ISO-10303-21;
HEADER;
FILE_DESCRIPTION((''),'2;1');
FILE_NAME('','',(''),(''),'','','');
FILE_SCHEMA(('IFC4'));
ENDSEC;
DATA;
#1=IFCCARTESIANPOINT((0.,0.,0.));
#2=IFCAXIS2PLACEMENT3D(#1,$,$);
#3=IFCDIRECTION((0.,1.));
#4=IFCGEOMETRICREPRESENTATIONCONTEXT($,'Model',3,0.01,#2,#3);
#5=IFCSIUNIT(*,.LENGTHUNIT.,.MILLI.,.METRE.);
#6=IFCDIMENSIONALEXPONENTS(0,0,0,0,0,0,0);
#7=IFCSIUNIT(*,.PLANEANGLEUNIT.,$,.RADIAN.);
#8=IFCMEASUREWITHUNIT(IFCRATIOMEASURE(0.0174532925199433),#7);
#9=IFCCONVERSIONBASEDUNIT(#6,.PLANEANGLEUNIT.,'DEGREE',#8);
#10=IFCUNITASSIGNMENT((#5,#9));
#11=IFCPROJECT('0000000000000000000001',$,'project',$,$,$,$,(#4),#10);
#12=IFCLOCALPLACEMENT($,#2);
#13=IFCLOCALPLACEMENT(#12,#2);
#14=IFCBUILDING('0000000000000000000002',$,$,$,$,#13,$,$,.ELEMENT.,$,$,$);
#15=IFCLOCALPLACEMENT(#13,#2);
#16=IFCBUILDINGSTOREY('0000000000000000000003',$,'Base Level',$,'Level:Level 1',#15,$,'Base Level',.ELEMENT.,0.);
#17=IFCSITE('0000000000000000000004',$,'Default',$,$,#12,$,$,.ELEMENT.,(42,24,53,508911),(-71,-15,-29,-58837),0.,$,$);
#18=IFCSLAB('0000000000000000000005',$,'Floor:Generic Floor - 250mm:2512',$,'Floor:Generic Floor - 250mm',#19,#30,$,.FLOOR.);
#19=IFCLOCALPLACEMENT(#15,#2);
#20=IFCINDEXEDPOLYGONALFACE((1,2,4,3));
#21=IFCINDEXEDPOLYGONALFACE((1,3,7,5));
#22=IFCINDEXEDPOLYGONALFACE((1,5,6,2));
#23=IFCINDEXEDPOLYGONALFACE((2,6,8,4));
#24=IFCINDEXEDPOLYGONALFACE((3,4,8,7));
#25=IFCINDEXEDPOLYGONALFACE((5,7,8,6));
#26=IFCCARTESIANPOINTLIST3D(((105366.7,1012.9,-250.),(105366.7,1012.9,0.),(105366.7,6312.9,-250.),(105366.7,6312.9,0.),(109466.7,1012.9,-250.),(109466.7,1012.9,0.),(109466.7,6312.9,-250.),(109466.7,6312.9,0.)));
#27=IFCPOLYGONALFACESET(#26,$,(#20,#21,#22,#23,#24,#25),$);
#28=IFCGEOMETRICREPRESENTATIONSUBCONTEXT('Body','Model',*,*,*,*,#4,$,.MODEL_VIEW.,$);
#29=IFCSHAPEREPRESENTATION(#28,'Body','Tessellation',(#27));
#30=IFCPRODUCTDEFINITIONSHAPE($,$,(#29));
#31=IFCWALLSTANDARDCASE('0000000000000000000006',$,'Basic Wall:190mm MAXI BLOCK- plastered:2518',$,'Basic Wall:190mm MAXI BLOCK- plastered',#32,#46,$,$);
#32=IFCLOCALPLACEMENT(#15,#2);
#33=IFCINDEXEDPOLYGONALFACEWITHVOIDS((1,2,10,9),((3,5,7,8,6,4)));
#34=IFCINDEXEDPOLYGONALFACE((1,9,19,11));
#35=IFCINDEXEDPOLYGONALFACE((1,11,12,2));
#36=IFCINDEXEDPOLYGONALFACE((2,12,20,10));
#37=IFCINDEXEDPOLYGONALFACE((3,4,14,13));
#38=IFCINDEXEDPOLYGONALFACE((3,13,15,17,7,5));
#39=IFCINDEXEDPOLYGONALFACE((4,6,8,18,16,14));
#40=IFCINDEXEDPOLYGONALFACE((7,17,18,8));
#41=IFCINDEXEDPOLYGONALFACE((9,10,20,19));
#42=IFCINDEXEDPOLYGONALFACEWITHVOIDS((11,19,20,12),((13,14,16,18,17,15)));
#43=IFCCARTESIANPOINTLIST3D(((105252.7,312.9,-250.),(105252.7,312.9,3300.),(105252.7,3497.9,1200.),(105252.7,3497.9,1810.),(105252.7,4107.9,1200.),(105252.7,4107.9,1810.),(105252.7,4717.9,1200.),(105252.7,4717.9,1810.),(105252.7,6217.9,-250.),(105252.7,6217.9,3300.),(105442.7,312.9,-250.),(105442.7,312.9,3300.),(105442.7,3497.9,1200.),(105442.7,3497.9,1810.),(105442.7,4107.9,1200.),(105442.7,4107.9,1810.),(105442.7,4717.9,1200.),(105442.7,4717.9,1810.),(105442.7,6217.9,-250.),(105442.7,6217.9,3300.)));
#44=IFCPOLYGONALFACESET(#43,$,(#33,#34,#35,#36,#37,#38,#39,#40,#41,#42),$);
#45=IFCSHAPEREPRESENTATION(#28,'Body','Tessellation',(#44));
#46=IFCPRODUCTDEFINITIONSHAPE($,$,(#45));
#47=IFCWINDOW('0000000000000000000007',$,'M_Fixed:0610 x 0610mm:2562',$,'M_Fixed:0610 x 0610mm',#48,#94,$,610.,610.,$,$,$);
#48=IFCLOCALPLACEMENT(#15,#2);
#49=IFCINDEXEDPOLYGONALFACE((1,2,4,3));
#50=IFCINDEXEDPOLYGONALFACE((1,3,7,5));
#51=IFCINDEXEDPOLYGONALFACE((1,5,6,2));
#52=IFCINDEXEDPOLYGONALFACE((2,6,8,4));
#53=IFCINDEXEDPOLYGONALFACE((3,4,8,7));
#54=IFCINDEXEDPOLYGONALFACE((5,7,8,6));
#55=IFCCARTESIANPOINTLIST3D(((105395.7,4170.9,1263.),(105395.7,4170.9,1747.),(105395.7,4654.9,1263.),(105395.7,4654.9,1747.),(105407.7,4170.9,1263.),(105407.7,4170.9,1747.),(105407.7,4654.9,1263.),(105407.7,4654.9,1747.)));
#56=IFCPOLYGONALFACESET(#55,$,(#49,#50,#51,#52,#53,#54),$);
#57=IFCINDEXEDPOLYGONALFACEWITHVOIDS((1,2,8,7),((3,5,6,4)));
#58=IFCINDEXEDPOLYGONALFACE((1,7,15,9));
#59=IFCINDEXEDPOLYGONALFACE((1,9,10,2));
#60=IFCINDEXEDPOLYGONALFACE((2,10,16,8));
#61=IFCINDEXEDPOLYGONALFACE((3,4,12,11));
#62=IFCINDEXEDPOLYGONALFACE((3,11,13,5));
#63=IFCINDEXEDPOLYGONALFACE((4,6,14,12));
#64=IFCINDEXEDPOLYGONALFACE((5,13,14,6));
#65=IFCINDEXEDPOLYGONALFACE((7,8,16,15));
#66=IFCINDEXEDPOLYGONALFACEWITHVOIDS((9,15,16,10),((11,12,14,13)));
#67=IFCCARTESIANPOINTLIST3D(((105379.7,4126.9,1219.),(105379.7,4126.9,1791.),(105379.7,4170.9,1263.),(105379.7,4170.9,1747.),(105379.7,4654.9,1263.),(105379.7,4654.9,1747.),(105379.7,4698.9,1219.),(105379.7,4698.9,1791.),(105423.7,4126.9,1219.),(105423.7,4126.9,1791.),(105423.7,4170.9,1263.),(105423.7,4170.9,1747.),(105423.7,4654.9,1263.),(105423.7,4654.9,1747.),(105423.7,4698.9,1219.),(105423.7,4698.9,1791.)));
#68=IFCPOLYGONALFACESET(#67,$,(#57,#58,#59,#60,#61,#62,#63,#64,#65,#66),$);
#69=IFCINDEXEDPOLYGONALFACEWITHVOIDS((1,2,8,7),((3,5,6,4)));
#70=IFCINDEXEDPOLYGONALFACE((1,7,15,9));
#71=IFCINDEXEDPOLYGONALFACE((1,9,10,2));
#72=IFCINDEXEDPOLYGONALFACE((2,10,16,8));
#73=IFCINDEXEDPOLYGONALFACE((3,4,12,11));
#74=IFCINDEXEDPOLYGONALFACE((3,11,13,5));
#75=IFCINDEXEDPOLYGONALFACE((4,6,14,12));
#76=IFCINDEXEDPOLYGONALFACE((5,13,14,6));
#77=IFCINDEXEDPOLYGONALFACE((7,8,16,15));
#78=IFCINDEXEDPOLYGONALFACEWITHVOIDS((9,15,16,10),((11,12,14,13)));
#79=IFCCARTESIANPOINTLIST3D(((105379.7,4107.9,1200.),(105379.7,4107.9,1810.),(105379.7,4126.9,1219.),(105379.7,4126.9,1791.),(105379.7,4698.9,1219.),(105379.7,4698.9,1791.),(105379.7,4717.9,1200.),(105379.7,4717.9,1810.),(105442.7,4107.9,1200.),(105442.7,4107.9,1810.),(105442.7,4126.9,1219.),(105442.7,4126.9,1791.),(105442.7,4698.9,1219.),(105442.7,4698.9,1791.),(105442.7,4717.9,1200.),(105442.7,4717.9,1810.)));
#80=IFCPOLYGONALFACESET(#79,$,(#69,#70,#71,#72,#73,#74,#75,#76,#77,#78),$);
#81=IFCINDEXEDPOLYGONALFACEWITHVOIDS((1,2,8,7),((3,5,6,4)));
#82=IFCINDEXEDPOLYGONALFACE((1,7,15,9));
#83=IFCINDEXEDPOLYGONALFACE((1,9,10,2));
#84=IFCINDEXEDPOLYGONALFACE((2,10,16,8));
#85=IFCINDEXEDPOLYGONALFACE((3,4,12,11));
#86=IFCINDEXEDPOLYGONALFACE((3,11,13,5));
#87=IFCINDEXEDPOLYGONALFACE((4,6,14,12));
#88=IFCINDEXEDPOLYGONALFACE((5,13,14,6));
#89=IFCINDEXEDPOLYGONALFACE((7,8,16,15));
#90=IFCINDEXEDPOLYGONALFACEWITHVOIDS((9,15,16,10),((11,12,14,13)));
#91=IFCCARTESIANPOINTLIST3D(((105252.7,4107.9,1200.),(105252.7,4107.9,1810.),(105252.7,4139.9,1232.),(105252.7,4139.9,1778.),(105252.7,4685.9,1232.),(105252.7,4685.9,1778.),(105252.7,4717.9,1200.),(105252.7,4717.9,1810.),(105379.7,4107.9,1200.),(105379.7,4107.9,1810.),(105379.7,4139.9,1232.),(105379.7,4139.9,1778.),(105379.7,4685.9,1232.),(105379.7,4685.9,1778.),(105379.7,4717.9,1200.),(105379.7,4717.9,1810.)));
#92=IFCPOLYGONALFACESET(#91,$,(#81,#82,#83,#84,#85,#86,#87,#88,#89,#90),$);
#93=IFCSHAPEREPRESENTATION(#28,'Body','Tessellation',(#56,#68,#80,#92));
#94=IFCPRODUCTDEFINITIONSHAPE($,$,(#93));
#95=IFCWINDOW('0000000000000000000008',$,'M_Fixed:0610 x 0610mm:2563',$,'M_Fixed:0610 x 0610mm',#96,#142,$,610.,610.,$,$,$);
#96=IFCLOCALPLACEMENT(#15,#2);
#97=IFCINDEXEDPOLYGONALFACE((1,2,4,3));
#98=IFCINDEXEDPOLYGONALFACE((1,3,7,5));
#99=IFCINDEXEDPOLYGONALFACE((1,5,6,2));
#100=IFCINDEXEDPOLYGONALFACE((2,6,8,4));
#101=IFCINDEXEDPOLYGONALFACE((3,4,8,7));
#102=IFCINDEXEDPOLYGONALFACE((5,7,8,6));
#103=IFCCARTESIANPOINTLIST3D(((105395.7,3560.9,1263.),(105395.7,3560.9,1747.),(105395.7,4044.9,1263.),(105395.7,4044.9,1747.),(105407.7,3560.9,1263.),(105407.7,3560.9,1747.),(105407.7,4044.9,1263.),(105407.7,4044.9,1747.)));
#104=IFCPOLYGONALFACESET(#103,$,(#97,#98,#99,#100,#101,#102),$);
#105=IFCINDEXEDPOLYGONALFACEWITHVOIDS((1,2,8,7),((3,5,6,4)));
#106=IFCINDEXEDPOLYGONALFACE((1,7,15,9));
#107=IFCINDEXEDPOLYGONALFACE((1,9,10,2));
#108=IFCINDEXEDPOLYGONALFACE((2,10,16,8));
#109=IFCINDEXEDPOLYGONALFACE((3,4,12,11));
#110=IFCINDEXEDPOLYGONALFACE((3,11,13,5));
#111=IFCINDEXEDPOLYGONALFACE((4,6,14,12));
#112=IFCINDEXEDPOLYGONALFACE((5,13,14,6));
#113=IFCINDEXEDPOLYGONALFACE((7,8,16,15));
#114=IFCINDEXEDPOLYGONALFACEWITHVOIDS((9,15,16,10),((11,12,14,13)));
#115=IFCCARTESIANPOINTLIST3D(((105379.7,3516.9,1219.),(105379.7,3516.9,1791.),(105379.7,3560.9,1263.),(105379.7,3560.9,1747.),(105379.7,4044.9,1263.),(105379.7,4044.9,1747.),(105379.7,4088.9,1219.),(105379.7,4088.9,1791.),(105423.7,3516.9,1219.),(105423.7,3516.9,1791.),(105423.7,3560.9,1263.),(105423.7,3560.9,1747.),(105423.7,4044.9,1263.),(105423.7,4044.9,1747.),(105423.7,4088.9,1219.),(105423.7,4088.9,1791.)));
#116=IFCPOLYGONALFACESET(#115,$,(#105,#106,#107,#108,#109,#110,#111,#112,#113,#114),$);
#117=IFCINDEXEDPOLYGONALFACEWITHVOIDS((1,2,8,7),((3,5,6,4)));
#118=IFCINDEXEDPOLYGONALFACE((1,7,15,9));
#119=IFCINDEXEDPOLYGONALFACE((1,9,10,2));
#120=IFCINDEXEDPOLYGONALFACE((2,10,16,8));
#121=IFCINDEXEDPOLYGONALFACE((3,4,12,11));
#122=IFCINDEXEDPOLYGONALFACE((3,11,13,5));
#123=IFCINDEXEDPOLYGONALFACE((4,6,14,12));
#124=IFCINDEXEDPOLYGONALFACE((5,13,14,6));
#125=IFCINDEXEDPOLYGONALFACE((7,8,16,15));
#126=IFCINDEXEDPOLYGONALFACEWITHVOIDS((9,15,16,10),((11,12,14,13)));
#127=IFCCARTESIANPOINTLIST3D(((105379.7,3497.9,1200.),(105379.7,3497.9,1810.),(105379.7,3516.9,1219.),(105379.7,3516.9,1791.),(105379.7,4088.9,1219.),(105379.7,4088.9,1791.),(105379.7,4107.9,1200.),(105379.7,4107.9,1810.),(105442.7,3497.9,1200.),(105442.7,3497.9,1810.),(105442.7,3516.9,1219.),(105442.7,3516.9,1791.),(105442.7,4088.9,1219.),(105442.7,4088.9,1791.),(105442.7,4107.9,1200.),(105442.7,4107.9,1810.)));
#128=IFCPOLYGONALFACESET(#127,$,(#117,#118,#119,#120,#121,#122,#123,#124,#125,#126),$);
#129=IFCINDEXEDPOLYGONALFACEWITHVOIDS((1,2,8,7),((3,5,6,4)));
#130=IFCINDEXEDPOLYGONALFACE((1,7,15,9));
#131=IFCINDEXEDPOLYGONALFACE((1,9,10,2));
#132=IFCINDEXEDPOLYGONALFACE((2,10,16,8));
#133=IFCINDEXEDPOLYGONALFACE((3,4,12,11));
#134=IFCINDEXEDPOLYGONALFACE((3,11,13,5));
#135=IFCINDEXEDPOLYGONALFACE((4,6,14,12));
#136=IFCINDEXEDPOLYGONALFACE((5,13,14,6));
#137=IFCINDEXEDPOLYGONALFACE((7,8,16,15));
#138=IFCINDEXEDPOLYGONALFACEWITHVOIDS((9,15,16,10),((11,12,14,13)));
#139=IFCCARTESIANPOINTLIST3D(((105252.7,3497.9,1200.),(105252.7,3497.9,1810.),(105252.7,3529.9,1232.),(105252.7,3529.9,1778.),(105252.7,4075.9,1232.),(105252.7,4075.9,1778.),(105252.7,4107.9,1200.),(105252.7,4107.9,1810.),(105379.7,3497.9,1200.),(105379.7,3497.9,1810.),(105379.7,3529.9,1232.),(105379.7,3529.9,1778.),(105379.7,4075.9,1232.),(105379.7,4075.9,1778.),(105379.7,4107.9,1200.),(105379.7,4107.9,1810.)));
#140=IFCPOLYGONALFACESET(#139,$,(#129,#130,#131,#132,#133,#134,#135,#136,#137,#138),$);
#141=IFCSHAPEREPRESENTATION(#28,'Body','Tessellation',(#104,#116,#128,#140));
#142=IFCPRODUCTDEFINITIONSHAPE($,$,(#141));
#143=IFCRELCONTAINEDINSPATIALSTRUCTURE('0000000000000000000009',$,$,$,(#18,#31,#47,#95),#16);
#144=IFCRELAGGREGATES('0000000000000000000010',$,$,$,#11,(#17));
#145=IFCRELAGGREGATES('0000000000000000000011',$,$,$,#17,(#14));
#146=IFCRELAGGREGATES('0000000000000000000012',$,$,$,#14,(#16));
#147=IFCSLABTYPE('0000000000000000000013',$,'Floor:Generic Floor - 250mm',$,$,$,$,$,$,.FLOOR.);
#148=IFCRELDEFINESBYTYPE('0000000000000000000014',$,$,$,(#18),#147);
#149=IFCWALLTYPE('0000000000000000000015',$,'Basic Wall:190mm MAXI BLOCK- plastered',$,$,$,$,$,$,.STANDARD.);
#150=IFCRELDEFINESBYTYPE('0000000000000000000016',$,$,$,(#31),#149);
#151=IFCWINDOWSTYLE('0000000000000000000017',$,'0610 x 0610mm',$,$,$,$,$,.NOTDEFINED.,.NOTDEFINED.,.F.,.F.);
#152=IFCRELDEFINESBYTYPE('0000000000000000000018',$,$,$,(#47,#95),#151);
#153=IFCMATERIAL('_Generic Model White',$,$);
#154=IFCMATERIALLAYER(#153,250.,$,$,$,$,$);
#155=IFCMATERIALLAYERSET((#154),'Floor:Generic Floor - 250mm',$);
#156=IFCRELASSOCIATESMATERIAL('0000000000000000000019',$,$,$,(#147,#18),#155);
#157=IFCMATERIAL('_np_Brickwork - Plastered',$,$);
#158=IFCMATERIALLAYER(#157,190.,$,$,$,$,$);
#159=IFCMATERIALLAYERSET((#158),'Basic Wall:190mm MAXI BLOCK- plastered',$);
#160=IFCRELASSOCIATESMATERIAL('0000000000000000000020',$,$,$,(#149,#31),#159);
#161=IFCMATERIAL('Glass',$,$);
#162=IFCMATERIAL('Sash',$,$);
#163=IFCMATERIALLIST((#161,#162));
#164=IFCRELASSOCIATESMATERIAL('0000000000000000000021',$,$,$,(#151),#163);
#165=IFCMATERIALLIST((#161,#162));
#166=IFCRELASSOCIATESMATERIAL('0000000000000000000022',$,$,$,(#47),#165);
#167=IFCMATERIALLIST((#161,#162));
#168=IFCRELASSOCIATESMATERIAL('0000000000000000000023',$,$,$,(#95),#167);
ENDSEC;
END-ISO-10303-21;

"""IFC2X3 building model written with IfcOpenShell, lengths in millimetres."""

from ifc_helpers import new_model, entity, si_unit, converted_unit, direction, frame, frame_2d, origin, origin_2d_with_axis, place, context, subcontext, project, spatial, polyline, rectangle, outline, extrude, source, transform, mapped, material, material_list, layer, layer_set, layer_usage, type_object, type_shapes, element, fill, save


model = new_model("IFC2X3")

# Units and contexts
model_context = context("Model", 3, precision=0.01, world=origin(), true_north=direction((0.0, 1.0)))
body_context = subcontext(model_context, "Body", "Model", "MODEL_VIEW")
ifc_project = project(units=[si_unit("LENGTHUNIT", "METRE", prefix="MILLI"), converted_unit("PLANEANGLEUNIT", "DEGREE", entity("IfcRatioMeasure", 0.0174532925199433), si_unit("PLANEANGLEUNIT", "RADIAN"), dimensions=[0, 0, 0, 0, 0, 0, 0])], contexts=[model_context])

# Site, building, storey
site_placement = place(None, origin())
site = spatial("IfcSite", under=ifc_project, at=site_placement, Name="Default", CompositionType="ELEMENT", RefLatitude=(42, 24, 53, 508911), RefLongitude=(-71, -15, -29, -58837), RefElevation=0.0)
building_placement = place(site_placement, origin())
building = spatial("IfcBuilding", under=site, at=building_placement, CompositionType="ELEMENT")
storey_placement = place(building_placement, origin())
storey = spatial("IfcBuildingStorey", under=building, at=storey_placement, Name="Base Level", ObjectType="Level:Level 1", LongName="Base Level", CompositionType="ELEMENT", Elevation=0.0)

# Slab
ifc_material_1 = material(Name="_Generic Model White")
ifc_layer_1 = layer(ifc_material_1, 250.0)
ifc_layer_set_1 = layer_set([ifc_layer_1], Name="Floor:Generic Floor - 250mm")
ifc_layer_usage_1 = layer_usage(ifc_layer_set_1, "AXIS3", "POSITIVE", 0.0)
slab_type = type_object("IfcSlabType", Name="Floor:Generic Floor - 250mm", PredefinedType="FLOOR", material=ifc_layer_set_1)
slab_placement = place(building_placement, origin())
element("IfcSlab", 1, at=slab_placement, inside=storey, type_object=slab_type, material=ifc_layer_usage_1, Name="Floor:Generic Floor - 250mm:2512", ObjectType="Floor:Generic Floor - 250mm", PredefinedType="FLOOR", context=body_context, shape_type="SweptSolid", body=[
    extrude(rectangle(XDim=5300.0, YDim=4100.0, at=origin_2d_with_axis()), frame((107416.7, 3662.9, 0.0), z_axis=(0.0, 0.0, -1.0), x_axis=(0.0, 1.0, 0.0)), (0.0, 0.0, 1.0), 250.0),
])

# Wall, openings, windows
ifc_material_2 = material(Name="_np_Brickwork - Plastered")
ifc_layer_2 = layer(ifc_material_2, 190.0)
ifc_layer_set_2 = layer_set([ifc_layer_2], Name="Basic Wall:190mm MAXI BLOCK- plastered")
ifc_layer_usage_2 = layer_usage(ifc_layer_set_2, "AXIS2", "NEGATIVE", 95.0)
wall_type = type_object("IfcWallType", Name="Basic Wall:190mm MAXI BLOCK- plastered", PredefinedType="STANDARD", material=ifc_layer_set_2)
wall_placement = place(building_placement, frame((105347.7, 312.9, -250.0), z_axis=(0.0, 0.0, 1.0), x_axis=(0.0, 1.0, 0.0)))
wall = element("IfcWallStandardCase", 2, at=wall_placement, inside=storey, type_object=wall_type, material=ifc_layer_usage_2, Name="Basic Wall:190mm MAXI BLOCK- plastered:2518", ObjectType="Basic Wall:190mm MAXI BLOCK- plastered", context=body_context, shape_type="SweptSolid", body=[
    extrude(rectangle(XDim=5905.0, YDim=190.0, at=frame_2d((2952.5, 0.0), x_axis=(-1.0, 0.0))), origin(), (0.0, 0.0, 1.0), 3550.0),
])
opening_1_placement = place(wall_placement, frame((4405.0, 95.0, 1450.0)))
opening_1 = element("IfcOpeningElement", 3, at=opening_1_placement, cuts=wall, ObjectType="Opening", context=body_context, shape_type="SweptSolid", body=[
    extrude(rectangle(XDim=610.0, YDim=610.0, at=frame_2d((305.0, 305.0), x_axis=(1.0, 0.0))), frame((0.0, 0.0, 0.0), z_axis=(0.0, -1.0, 0.0), x_axis=(0.0, 0.0, 1.0)), (0.0, 0.0, 1.0), 190.0),
])
opening_2_placement = place(wall_placement, frame((3795.0, 95.0, 1450.0)))
opening_2 = element("IfcOpeningElement", 4, at=opening_2_placement, cuts=wall, ObjectType="Opening", context=body_context, shape_type="SweptSolid", body=[
    extrude(rectangle(XDim=610.0, YDim=610.0, at=frame_2d((305.0, 305.0), x_axis=(1.0, 0.0))), frame((0.0, 0.0, 0.0), z_axis=(0.0, -1.0, 0.0), x_axis=(0.0, 0.0, 1.0)), (0.0, 0.0, 1.0), 190.0),
])
ifc_material_3 = material(Name="Glass")
ifc_material_4 = material(Name="Sash")
ifc_material_list_1 = material_list([ifc_material_3, ifc_material_4])
ifc_material_list_2 = material_list([ifc_material_3, ifc_material_4])
window_style = type_object("IfcWindowStyle", Name="0610 x 0610mm", ConstructionType="NOTDEFINED", OperationType="NOTDEFINED", ParameterTakesPrecedence=False, Sizeable=False, material=ifc_material_list_2)
shared_shape_1 = source(origin(), body_context, "Body", "SweptSolid", [
    extrude(rectangle(XDim=12.0, YDim=484.0, at=frame_2d((0.0, 0.0), x_axis=(1.0, 0.0))), frame((305.0, 149.0, 63.0), z_axis=(0.0, 0.0, 1.0), x_axis=(0.0, -1.0, 0.0)), (0.0, 0.0, 1.0), 484.0),
    extrude(outline(polyline([(-286.0, -286.0), (286.0, -286.0), (286.0, 286.0), (-286.0, 286.0), (-286.0, -286.0)]), holes=[polyline([(-242.0, -242.0), (-242.0, 242.0), (242.0, 242.0), (242.0, -242.0), (-242.0, -242.0)])]), frame((305.0, 127.0, 305.0), z_axis=(0.0, 1.0, 0.0), x_axis=(1.0, 0.0, 0.0)), (0.0, 0.0, 1.0), 44.0),
    extrude(outline(polyline([(-305.0, -305.0), (305.0, -305.0), (305.0, 305.0), (-305.0, 305.0), (-305.0, -305.0)]), holes=[polyline([(-286.0, -286.0), (-286.0, 286.0), (286.0, 286.0), (286.0, -286.0), (-286.0, -286.0)])]), frame((305.0, 127.0, 305.0), z_axis=(0.0, 1.0, 0.0), x_axis=(1.0, 0.0, 0.0)), (0.0, 0.0, 1.0), 63.0),
    extrude(outline(polyline([(-305.0, -305.0), (305.0, -305.0), (305.0, 305.0), (-305.0, 305.0), (-305.0, -305.0)]), holes=[polyline([(-273.0, -273.0), (-273.0, 273.0), (273.0, 273.0), (273.0, -273.0), (-273.0, -273.0)])]), frame((305.0, 0.0, 305.0), z_axis=(0.0, 1.0, 0.0), x_axis=(1.0, 0.0, 0.0)), (0.0, 0.0, 1.0), 127.0),
])
type_shapes(window_style, [shared_shape_1])
window_1_placement = place(opening_1_placement, frame((0.0, 0.0, 0.0), z_axis=(0.0, 0.0, 1.0), x_axis=(-1.0, 0.0, 0.0)))
window_1 = element("IfcWindow", 5, at=window_1_placement, inside=storey, type_object=window_style, material=ifc_material_list_1, Name="M_Fixed:0610 x 0610mm:2562", ObjectType="M_Fixed:0610 x 0610mm", OverallHeight=610.0, OverallWidth=610.0, context=body_context, shape_type="MappedRepresentation", body=[
    mapped(shared_shape_1, transform((0.0, 0.0, 0.0), scale=1.0)),
])
fill(opening_1, window_1)
ifc_material_list_3 = material_list([ifc_material_3, ifc_material_4])
window_2_placement = place(opening_2_placement, frame((0.0, 0.0, 0.0), z_axis=(0.0, 0.0, 1.0), x_axis=(-1.0, 0.0, 0.0)))
window_2 = element("IfcWindow", 6, at=window_2_placement, inside=storey, type_object=window_style, material=ifc_material_list_3, Name="M_Fixed:0610 x 0610mm:2563", ObjectType="M_Fixed:0610 x 0610mm", OverallHeight=610.0, OverallWidth=610.0, context=body_context, shape_type="MappedRepresentation", body=[
    mapped(shared_shape_1, transform((0.0, 0.0, 0.0), scale=1.0)),
])
fill(opening_2, window_2)

save(model, "model.ifc")
